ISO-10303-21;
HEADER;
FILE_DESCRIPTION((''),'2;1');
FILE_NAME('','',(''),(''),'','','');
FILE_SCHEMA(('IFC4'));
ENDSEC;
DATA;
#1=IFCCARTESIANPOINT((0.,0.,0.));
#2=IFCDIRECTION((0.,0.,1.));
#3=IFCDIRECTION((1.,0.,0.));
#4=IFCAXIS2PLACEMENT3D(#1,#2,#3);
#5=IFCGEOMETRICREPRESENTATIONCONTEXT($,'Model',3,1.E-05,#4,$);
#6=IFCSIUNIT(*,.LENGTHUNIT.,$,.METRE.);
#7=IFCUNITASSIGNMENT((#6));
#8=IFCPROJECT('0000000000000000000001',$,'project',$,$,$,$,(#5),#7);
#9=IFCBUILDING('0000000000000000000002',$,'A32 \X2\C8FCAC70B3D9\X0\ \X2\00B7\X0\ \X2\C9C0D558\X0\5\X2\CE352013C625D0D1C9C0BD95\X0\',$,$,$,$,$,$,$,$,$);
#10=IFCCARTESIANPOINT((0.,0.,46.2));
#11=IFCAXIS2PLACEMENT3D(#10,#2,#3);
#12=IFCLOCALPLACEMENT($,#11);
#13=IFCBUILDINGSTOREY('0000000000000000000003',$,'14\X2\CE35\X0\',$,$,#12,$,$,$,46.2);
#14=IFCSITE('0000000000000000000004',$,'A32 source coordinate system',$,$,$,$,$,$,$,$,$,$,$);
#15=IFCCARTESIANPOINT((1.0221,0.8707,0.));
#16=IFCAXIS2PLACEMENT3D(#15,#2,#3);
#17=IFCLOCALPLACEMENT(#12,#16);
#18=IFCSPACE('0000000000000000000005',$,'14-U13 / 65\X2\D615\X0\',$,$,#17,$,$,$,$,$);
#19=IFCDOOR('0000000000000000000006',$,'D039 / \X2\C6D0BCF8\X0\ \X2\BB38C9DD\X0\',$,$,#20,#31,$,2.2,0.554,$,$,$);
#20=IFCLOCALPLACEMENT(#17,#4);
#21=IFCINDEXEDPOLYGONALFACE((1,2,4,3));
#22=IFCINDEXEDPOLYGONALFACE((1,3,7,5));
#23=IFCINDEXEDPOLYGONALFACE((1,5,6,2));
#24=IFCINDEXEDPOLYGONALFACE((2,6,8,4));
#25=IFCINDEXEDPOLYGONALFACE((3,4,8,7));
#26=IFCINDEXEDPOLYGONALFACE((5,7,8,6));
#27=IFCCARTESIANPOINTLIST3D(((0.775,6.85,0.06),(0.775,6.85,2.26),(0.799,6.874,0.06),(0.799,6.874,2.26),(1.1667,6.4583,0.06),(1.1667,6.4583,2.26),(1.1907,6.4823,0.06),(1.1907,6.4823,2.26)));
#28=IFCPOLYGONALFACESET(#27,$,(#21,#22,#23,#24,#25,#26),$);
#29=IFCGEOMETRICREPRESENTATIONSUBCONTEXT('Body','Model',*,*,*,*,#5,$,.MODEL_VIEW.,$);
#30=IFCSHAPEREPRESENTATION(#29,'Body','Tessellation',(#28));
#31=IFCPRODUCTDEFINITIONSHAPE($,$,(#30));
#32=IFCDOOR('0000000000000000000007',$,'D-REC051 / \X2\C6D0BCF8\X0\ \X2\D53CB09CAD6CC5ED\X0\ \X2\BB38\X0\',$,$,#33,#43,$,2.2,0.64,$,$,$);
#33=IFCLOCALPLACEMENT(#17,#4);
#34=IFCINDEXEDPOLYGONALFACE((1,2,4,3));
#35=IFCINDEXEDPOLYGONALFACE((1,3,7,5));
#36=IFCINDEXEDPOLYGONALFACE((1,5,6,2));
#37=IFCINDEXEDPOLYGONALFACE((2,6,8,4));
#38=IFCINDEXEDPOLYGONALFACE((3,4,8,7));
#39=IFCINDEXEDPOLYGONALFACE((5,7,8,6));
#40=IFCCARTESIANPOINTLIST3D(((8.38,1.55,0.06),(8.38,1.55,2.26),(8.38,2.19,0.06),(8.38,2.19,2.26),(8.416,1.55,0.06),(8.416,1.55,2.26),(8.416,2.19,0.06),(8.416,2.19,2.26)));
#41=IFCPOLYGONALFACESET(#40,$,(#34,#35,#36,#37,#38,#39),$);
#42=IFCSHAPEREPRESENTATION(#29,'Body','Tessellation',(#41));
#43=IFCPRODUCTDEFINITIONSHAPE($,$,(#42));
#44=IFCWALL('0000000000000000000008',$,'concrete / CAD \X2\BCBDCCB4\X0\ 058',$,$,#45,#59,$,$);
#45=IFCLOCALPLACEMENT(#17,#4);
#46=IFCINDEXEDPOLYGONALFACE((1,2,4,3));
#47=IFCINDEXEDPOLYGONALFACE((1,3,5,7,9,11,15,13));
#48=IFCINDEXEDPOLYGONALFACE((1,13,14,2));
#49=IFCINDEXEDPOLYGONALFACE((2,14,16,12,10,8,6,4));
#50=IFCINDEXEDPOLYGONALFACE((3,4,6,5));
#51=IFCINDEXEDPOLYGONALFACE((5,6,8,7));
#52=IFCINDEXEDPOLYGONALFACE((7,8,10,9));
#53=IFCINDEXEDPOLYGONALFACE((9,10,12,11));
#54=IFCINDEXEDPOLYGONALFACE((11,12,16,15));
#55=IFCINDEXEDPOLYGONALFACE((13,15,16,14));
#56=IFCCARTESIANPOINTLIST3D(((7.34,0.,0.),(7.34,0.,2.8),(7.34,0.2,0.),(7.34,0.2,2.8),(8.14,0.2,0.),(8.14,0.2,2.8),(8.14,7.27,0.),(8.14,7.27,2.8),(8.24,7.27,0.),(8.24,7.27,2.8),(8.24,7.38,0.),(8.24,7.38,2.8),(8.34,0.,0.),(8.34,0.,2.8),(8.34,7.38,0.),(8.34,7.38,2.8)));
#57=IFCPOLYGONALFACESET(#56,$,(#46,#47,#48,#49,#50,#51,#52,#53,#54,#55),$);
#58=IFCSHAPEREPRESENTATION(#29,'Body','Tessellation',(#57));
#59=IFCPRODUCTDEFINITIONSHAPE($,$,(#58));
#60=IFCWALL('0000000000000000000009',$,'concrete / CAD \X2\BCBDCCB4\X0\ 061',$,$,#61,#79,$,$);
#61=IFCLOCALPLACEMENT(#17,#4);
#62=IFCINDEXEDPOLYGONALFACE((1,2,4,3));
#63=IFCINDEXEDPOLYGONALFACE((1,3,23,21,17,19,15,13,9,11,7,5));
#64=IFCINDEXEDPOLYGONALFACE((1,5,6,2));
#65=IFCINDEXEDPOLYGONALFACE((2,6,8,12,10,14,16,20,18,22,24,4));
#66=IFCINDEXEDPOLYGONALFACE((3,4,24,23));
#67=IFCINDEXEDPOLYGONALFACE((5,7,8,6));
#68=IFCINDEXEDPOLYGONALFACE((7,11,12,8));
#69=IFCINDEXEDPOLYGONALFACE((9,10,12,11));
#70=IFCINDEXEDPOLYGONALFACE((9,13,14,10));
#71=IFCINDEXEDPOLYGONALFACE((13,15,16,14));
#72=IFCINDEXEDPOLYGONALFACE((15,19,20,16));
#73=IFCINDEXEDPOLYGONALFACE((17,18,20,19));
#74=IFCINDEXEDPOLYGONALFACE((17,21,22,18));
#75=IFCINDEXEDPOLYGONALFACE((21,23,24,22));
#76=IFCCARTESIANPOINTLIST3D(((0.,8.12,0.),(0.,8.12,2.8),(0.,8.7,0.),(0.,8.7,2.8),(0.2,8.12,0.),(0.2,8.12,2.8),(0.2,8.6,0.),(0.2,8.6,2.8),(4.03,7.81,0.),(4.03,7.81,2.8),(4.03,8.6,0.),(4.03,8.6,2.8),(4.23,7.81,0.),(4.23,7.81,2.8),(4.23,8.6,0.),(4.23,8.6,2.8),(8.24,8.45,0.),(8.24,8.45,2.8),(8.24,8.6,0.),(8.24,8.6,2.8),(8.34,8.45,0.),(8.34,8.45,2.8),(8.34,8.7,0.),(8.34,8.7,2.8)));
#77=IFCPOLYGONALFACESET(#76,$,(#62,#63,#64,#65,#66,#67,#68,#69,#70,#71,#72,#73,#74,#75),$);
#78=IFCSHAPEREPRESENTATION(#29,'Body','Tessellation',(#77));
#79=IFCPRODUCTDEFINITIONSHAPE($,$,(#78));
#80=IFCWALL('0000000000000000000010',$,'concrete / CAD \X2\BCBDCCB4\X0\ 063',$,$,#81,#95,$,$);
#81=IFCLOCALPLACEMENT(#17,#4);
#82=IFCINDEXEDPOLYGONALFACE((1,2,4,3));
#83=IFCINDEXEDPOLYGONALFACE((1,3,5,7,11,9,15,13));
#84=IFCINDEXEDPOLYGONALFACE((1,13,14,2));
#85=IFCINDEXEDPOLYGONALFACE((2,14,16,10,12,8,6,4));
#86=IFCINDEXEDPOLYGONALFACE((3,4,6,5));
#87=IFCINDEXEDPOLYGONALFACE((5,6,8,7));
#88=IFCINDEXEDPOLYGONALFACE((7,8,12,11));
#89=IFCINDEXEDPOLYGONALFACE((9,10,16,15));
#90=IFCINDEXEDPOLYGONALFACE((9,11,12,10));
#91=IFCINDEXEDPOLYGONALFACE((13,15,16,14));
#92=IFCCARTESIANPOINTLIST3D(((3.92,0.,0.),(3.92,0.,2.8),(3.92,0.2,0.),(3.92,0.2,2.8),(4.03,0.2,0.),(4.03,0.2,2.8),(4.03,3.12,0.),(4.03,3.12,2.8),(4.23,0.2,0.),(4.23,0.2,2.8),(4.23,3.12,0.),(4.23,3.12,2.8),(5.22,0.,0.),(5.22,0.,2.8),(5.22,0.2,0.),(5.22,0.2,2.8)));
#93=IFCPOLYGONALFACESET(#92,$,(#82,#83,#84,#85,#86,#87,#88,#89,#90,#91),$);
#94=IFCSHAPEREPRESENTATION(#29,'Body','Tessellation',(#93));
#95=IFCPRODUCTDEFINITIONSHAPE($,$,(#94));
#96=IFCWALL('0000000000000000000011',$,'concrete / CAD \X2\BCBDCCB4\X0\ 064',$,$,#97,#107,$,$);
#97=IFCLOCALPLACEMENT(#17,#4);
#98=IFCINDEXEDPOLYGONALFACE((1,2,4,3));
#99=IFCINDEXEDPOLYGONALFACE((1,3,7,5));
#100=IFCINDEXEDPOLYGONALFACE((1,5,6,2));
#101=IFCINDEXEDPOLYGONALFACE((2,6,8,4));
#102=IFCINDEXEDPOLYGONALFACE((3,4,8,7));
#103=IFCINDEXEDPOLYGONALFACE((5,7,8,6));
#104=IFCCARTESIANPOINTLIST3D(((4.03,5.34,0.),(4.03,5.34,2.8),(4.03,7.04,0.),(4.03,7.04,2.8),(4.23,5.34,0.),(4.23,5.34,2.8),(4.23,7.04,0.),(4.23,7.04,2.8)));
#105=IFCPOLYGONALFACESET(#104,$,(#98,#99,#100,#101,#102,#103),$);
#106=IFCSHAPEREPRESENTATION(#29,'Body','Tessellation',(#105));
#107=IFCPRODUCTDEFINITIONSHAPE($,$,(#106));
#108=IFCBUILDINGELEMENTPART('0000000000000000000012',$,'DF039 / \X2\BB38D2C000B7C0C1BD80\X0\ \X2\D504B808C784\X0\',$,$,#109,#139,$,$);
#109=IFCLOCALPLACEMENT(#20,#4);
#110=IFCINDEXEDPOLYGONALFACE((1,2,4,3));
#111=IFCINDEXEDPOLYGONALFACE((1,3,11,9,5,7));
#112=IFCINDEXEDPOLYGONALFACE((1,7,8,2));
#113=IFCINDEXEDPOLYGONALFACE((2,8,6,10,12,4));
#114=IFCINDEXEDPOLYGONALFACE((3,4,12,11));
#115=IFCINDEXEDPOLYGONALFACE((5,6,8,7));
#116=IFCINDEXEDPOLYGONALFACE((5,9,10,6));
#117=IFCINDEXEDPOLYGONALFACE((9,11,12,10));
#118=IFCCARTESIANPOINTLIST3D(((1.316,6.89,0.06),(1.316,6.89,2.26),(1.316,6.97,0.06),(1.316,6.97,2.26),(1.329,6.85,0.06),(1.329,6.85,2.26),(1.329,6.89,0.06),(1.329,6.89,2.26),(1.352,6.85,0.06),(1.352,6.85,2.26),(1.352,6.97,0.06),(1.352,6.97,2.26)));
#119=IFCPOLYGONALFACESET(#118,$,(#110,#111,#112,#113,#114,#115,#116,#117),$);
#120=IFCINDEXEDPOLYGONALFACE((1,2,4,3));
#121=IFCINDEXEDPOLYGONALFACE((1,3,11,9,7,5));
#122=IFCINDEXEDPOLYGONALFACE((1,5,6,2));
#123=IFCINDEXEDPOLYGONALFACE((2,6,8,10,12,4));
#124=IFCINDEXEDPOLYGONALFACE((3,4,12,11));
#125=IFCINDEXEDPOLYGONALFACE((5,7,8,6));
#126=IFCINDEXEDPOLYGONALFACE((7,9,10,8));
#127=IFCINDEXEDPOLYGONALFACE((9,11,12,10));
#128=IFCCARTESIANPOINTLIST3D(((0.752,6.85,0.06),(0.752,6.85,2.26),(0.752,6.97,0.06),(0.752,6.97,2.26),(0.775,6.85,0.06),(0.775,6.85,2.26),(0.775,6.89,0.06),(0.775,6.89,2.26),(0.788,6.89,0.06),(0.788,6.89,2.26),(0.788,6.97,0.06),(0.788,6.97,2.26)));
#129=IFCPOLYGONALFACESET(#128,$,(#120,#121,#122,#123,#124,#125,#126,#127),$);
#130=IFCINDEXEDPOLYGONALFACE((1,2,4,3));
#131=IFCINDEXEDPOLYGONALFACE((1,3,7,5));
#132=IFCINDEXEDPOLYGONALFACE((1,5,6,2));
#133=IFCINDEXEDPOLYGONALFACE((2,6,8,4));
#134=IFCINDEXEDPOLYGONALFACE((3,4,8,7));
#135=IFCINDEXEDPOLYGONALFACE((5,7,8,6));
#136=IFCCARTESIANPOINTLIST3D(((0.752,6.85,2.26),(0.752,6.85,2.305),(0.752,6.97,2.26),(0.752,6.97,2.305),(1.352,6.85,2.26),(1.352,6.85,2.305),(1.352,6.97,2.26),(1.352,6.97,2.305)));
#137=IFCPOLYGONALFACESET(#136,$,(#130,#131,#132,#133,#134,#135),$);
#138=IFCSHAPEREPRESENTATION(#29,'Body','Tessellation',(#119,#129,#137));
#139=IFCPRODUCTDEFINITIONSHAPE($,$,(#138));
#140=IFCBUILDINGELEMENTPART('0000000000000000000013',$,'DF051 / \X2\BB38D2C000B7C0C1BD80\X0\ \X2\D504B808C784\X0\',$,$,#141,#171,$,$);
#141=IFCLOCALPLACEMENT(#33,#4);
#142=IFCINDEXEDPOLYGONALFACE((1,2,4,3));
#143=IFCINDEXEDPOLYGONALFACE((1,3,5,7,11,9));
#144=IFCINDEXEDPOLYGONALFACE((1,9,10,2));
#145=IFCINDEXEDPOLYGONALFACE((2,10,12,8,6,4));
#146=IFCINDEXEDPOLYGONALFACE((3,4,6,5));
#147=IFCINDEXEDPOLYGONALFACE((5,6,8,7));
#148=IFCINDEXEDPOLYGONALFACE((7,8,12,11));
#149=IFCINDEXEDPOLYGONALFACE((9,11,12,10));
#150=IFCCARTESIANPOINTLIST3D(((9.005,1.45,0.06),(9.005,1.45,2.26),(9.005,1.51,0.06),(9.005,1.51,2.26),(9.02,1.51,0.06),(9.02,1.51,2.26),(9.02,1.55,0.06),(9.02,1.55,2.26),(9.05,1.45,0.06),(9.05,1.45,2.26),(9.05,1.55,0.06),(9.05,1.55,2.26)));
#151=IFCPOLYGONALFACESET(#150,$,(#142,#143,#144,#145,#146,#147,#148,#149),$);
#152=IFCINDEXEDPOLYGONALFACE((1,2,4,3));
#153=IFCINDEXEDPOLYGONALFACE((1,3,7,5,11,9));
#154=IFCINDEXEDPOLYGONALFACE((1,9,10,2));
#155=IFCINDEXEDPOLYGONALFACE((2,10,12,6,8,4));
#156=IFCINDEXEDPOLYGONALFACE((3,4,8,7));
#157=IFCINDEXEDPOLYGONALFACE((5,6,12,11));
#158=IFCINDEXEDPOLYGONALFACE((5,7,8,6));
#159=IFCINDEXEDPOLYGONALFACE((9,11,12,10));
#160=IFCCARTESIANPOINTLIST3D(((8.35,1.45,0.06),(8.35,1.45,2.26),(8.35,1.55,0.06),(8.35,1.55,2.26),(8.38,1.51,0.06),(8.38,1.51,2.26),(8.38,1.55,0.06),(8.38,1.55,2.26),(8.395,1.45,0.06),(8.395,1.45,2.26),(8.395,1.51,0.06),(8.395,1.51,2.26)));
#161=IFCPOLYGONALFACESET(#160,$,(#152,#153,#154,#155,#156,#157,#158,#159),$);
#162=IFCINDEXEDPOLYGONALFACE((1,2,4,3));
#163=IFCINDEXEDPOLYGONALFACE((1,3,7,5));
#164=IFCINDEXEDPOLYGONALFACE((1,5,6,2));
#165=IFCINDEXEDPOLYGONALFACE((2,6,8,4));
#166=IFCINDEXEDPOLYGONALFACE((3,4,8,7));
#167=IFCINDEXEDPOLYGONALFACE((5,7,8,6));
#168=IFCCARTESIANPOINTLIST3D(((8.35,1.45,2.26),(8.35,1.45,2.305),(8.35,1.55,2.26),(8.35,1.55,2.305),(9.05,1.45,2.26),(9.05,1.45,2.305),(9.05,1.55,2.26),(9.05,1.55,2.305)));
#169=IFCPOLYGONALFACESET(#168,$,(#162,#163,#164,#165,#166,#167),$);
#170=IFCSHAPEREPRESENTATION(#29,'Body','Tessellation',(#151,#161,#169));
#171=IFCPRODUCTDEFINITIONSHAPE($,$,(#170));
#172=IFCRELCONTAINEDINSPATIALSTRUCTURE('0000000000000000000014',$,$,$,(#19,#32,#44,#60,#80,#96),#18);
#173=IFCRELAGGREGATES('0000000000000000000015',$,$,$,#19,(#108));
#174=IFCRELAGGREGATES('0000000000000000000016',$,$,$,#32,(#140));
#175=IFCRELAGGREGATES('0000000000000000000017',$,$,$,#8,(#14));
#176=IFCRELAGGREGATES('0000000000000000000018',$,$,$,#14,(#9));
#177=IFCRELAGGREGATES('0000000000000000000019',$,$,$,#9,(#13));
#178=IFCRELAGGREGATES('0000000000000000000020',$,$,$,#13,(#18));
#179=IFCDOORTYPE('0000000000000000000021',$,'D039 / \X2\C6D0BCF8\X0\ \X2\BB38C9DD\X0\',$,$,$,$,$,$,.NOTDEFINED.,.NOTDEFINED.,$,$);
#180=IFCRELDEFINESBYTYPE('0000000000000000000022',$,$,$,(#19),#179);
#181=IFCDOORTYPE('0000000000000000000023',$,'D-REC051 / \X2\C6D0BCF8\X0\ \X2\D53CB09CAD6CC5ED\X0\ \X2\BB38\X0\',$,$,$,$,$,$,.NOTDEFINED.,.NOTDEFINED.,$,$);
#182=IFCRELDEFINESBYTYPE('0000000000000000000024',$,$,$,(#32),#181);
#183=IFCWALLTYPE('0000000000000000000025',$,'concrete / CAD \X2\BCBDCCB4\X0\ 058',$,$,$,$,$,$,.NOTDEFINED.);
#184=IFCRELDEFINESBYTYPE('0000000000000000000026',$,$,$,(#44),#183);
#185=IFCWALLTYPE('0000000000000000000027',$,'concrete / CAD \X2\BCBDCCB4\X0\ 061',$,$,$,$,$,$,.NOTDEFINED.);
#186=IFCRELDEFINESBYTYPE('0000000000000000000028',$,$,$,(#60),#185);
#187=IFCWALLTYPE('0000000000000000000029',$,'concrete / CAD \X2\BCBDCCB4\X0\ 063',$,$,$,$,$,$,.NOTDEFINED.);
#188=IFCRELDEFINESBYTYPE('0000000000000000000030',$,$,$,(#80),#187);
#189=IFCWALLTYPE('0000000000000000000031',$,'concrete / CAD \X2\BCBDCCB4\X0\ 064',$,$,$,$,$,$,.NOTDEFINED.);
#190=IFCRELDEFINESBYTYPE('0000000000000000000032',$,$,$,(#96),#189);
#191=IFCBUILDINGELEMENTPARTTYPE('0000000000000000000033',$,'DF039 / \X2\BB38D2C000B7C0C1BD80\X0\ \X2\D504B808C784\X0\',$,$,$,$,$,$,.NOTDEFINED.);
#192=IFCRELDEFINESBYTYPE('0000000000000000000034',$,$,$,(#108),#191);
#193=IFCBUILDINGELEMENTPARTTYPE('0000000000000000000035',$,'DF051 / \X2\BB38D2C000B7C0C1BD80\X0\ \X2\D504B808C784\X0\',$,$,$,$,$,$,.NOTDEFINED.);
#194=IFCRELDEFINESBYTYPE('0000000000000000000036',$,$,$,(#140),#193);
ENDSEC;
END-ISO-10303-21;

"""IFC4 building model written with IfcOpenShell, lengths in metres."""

from ifc_helpers import new_model, si_unit, frame, origin, origin_with_axes, place, context, subcontext, project, spatial, polyline, outline, extrude, source, transform, mapped, type_object, type_shapes, element, aggregate, save


model = new_model("IFC4")

# Units and contexts
model_context = context("Model", 3, precision=1e-05, world=origin_with_axes())
body_context = subcontext(model_context, "Body", "Model", "MODEL_VIEW")
ifc_project = project(units=[si_unit("LENGTHUNIT", "METRE")], contexts=[model_context])

# Site, building, storey, space
storey_placement = place(None, frame((0.0, 0.0, 46.2), z_axis=(0.0, 0.0, 1.0), x_axis=(1.0, 0.0, 0.0)))
space_placement = place(storey_placement, frame((1.0221, 0.8707, 0.0), z_axis=(0.0, 0.0, 1.0), x_axis=(1.0, 0.0, 0.0)))
site = spatial("IfcSite", under=ifc_project, Name="A32 source coordinate system")
building = spatial("IfcBuilding", under=site, Name="A32 주거동 · 지하5층–옥탑지붕")
storey = spatial("IfcBuildingStorey", under=building, at=storey_placement, Name="14층", Elevation=46.2)
space = spatial("IfcSpace", under=storey, at=space_placement, Name="14-U13 / 65형")

# Doors
door_type_1 = type_object("IfcDoorType", Name="D039 / 원본 문짝", OperationType="NOTDEFINED", PredefinedType="NOTDEFINED")
shared_shape_1 = source(origin(), body_context, "Body", "SweptSolid", [
    extrude(outline(polyline([(1.1907, 6.4823), (1.1667, 6.4583), (0.775, 6.85), (0.799, 6.874), (1.1907, 6.4823)])), frame((0.0, 0.0, 0.06)), (0.0, 0.0, 1.0), 2.2),
])
type_shapes(door_type_1, [shared_shape_1])
door_1_placement = place(space_placement, origin_with_axes())
door_1 = element("IfcDoor", 1, at=door_1_placement, inside=space, type_object=door_type_1, Name="D039 / 원본 문짝", OverallHeight=2.2, OverallWidth=0.554, context=body_context, shape_type="MappedRepresentation", body=[
    mapped(shared_shape_1, transform((0.0, 0.0, 0.0), scale=1.0)),
])
door_type_2 = type_object("IfcDoorType", Name="D-REC051 / 원본 피난구역 문", OperationType="NOTDEFINED", PredefinedType="NOTDEFINED")
shared_shape_2 = source(origin(), body_context, "Body", "SweptSolid", [
    extrude(outline(polyline([(8.416, 2.19), (8.416, 1.55), (8.38, 1.55), (8.38, 2.19), (8.416, 2.19)])), frame((0.0, 0.0, 0.06)), (0.0, 0.0, 1.0), 2.2),
])
type_shapes(door_type_2, [shared_shape_2])
door_2_placement = place(space_placement, origin_with_axes())
door_2 = element("IfcDoor", 2, at=door_2_placement, inside=space, type_object=door_type_2, Name="D-REC051 / 원본 피난구역 문", OverallHeight=2.2, OverallWidth=0.64, context=body_context, shape_type="MappedRepresentation", body=[
    mapped(shared_shape_2, transform((0.0, 0.0, 0.0), scale=1.0)),
])

# Walls
wall_type_1 = type_object("IfcWallType", Name="concrete / CAD 벽체 058", PredefinedType="NOTDEFINED")
shared_shape_3 = source(origin(), body_context, "Body", "SweptSolid", [
    extrude(outline(polyline([(8.34, 0.0), (7.34, 0.0), (7.34, 0.2), (8.14, 0.2), (8.14, 7.27), (8.24, 7.27), (8.24, 7.38), (8.34, 7.38), (8.34, 0.0)])), origin(), (0.0, 0.0, 1.0), 2.8),
])
type_shapes(wall_type_1, [shared_shape_3])
wall_1_placement = place(space_placement, origin_with_axes())
element("IfcWall", 3, at=wall_1_placement, inside=space, type_object=wall_type_1, Name="concrete / CAD 벽체 058", context=body_context, shape_type="MappedRepresentation", body=[
    mapped(shared_shape_3, transform((0.0, 0.0, 0.0), scale=1.0)),
])
wall_type_2 = type_object("IfcWallType", Name="concrete / CAD 벽체 061", PredefinedType="NOTDEFINED")
shared_shape_4 = source(origin(), body_context, "Body", "SweptSolid", [
    extrude(outline(polyline([(0.2, 8.6), (0.2, 8.12), (0.0, 8.12), (0.0, 8.7), (8.34, 8.7), (8.34, 8.45), (8.24, 8.45), (8.24, 8.6), (4.23, 8.6), (4.23, 7.81), (4.03, 7.81), (4.03, 8.6), (0.2, 8.6)])), origin(), (0.0, 0.0, 1.0), 2.8),
])
type_shapes(wall_type_2, [shared_shape_4])
wall_2_placement = place(space_placement, origin_with_axes())
element("IfcWall", 4, at=wall_2_placement, inside=space, type_object=wall_type_2, Name="concrete / CAD 벽체 061", context=body_context, shape_type="MappedRepresentation", body=[
    mapped(shared_shape_4, transform((0.0, 0.0, 0.0), scale=1.0)),
])
wall_type_3 = type_object("IfcWallType", Name="concrete / CAD 벽체 063", PredefinedType="NOTDEFINED")
shared_shape_5 = source(origin(), body_context, "Body", "SweptSolid", [
    extrude(outline(polyline([(5.22, 0.0), (3.92, 0.0), (3.92, 0.2), (4.03, 0.2), (4.03, 3.12), (4.23, 3.12), (4.23, 0.2), (5.22, 0.2), (5.22, 0.0)])), origin(), (0.0, 0.0, 1.0), 2.8),
])
type_shapes(wall_type_3, [shared_shape_5])
wall_3_placement = place(space_placement, origin_with_axes())
element("IfcWall", 5, at=wall_3_placement, inside=space, type_object=wall_type_3, Name="concrete / CAD 벽체 063", context=body_context, shape_type="MappedRepresentation", body=[
    mapped(shared_shape_5, transform((0.0, 0.0, 0.0), scale=1.0)),
])
wall_type_4 = type_object("IfcWallType", Name="concrete / CAD 벽체 064", PredefinedType="NOTDEFINED")
shared_shape_6 = source(origin(), body_context, "Body", "SweptSolid", [
    extrude(outline(polyline([(4.03, 7.04), (4.23, 7.04), (4.23, 5.34), (4.03, 5.34), (4.03, 7.04)])), origin(), (0.0, 0.0, 1.0), 2.8),
])
type_shapes(wall_type_4, [shared_shape_6])
wall_4_placement = place(space_placement, origin_with_axes())
element("IfcWall", 6, at=wall_4_placement, inside=space, type_object=wall_type_4, Name="concrete / CAD 벽체 064", context=body_context, shape_type="MappedRepresentation", body=[
    mapped(shared_shape_6, transform((0.0, 0.0, 0.0), scale=1.0)),
])

# Building element parts
building_element_part_type_1 = type_object("IfcBuildingElementPartType", Name="DF039 / 문틀·상부 프레임", PredefinedType="NOTDEFINED")
shared_shape_7 = source(origin(), body_context, "Body", "SweptSolid", [
    extrude(outline(polyline([(1.352, 6.85), (1.329, 6.85), (1.329, 6.89), (1.316, 6.89), (1.316, 6.97), (1.352, 6.97), (1.352, 6.85)])), frame((0.0, 0.0, 0.06)), (0.0, 0.0, 1.0), 2.2),
    extrude(outline(polyline([(0.788, 6.97), (0.788, 6.89), (0.775, 6.89), (0.775, 6.85), (0.752, 6.85), (0.752, 6.97), (0.788, 6.97)])), frame((0.0, 0.0, 0.06)), (0.0, 0.0, 1.0), 2.2),
    extrude(outline(polyline([(0.752, 6.85), (0.752, 6.97), (1.352, 6.97), (1.352, 6.85), (0.752, 6.85)])), frame((0.0, 0.0, 2.26)), (0.0, 0.0, 1.0), 0.045),
])
type_shapes(building_element_part_type_1, [shared_shape_7])
building_element_part_1_placement = place(door_1_placement, origin_with_axes())
building_element_part_1 = element("IfcBuildingElementPart", 7, at=building_element_part_1_placement, type_object=building_element_part_type_1, Name="DF039 / 문틀·상부 프레임", context=body_context, shape_type="MappedRepresentation", body=[
    mapped(shared_shape_7, transform((0.0, 0.0, 0.0), scale=1.0)),
])
aggregate(door_1, [building_element_part_1])
building_element_part_type_2 = type_object("IfcBuildingElementPartType", Name="DF051 / 문틀·상부 프레임", PredefinedType="NOTDEFINED")
shared_shape_8 = source(origin(), body_context, "Body", "SweptSolid", [
    extrude(outline(polyline([(9.05, 1.45), (9.005, 1.45), (9.005, 1.51), (9.02, 1.51), (9.02, 1.55), (9.05, 1.55), (9.05, 1.45)])), frame((0.0, 0.0, 0.06)), (0.0, 0.0, 1.0), 2.2),
    extrude(outline(polyline([(8.38, 1.55), (8.38, 1.51), (8.395, 1.51), (8.395, 1.45), (8.35, 1.45), (8.35, 1.55), (8.38, 1.55)])), frame((0.0, 0.0, 0.06)), (0.0, 0.0, 1.0), 2.2),
    extrude(outline(polyline([(8.35, 1.45), (8.35, 1.55), (9.05, 1.55), (9.05, 1.45), (8.35, 1.45)])), frame((0.0, 0.0, 2.26)), (0.0, 0.0, 1.0), 0.045),
])
type_shapes(building_element_part_type_2, [shared_shape_8])
building_element_part_2_placement = place(door_2_placement, origin_with_axes())
building_element_part_2 = element("IfcBuildingElementPart", 8, at=building_element_part_2_placement, type_object=building_element_part_type_2, Name="DF051 / 문틀·상부 프레임", context=body_context, shape_type="MappedRepresentation", body=[
    mapped(shared_shape_8, transform((0.0, 0.0, 0.0), scale=1.0)),
])
aggregate(door_2, [building_element_part_2])

save(model, "model.ifc")
